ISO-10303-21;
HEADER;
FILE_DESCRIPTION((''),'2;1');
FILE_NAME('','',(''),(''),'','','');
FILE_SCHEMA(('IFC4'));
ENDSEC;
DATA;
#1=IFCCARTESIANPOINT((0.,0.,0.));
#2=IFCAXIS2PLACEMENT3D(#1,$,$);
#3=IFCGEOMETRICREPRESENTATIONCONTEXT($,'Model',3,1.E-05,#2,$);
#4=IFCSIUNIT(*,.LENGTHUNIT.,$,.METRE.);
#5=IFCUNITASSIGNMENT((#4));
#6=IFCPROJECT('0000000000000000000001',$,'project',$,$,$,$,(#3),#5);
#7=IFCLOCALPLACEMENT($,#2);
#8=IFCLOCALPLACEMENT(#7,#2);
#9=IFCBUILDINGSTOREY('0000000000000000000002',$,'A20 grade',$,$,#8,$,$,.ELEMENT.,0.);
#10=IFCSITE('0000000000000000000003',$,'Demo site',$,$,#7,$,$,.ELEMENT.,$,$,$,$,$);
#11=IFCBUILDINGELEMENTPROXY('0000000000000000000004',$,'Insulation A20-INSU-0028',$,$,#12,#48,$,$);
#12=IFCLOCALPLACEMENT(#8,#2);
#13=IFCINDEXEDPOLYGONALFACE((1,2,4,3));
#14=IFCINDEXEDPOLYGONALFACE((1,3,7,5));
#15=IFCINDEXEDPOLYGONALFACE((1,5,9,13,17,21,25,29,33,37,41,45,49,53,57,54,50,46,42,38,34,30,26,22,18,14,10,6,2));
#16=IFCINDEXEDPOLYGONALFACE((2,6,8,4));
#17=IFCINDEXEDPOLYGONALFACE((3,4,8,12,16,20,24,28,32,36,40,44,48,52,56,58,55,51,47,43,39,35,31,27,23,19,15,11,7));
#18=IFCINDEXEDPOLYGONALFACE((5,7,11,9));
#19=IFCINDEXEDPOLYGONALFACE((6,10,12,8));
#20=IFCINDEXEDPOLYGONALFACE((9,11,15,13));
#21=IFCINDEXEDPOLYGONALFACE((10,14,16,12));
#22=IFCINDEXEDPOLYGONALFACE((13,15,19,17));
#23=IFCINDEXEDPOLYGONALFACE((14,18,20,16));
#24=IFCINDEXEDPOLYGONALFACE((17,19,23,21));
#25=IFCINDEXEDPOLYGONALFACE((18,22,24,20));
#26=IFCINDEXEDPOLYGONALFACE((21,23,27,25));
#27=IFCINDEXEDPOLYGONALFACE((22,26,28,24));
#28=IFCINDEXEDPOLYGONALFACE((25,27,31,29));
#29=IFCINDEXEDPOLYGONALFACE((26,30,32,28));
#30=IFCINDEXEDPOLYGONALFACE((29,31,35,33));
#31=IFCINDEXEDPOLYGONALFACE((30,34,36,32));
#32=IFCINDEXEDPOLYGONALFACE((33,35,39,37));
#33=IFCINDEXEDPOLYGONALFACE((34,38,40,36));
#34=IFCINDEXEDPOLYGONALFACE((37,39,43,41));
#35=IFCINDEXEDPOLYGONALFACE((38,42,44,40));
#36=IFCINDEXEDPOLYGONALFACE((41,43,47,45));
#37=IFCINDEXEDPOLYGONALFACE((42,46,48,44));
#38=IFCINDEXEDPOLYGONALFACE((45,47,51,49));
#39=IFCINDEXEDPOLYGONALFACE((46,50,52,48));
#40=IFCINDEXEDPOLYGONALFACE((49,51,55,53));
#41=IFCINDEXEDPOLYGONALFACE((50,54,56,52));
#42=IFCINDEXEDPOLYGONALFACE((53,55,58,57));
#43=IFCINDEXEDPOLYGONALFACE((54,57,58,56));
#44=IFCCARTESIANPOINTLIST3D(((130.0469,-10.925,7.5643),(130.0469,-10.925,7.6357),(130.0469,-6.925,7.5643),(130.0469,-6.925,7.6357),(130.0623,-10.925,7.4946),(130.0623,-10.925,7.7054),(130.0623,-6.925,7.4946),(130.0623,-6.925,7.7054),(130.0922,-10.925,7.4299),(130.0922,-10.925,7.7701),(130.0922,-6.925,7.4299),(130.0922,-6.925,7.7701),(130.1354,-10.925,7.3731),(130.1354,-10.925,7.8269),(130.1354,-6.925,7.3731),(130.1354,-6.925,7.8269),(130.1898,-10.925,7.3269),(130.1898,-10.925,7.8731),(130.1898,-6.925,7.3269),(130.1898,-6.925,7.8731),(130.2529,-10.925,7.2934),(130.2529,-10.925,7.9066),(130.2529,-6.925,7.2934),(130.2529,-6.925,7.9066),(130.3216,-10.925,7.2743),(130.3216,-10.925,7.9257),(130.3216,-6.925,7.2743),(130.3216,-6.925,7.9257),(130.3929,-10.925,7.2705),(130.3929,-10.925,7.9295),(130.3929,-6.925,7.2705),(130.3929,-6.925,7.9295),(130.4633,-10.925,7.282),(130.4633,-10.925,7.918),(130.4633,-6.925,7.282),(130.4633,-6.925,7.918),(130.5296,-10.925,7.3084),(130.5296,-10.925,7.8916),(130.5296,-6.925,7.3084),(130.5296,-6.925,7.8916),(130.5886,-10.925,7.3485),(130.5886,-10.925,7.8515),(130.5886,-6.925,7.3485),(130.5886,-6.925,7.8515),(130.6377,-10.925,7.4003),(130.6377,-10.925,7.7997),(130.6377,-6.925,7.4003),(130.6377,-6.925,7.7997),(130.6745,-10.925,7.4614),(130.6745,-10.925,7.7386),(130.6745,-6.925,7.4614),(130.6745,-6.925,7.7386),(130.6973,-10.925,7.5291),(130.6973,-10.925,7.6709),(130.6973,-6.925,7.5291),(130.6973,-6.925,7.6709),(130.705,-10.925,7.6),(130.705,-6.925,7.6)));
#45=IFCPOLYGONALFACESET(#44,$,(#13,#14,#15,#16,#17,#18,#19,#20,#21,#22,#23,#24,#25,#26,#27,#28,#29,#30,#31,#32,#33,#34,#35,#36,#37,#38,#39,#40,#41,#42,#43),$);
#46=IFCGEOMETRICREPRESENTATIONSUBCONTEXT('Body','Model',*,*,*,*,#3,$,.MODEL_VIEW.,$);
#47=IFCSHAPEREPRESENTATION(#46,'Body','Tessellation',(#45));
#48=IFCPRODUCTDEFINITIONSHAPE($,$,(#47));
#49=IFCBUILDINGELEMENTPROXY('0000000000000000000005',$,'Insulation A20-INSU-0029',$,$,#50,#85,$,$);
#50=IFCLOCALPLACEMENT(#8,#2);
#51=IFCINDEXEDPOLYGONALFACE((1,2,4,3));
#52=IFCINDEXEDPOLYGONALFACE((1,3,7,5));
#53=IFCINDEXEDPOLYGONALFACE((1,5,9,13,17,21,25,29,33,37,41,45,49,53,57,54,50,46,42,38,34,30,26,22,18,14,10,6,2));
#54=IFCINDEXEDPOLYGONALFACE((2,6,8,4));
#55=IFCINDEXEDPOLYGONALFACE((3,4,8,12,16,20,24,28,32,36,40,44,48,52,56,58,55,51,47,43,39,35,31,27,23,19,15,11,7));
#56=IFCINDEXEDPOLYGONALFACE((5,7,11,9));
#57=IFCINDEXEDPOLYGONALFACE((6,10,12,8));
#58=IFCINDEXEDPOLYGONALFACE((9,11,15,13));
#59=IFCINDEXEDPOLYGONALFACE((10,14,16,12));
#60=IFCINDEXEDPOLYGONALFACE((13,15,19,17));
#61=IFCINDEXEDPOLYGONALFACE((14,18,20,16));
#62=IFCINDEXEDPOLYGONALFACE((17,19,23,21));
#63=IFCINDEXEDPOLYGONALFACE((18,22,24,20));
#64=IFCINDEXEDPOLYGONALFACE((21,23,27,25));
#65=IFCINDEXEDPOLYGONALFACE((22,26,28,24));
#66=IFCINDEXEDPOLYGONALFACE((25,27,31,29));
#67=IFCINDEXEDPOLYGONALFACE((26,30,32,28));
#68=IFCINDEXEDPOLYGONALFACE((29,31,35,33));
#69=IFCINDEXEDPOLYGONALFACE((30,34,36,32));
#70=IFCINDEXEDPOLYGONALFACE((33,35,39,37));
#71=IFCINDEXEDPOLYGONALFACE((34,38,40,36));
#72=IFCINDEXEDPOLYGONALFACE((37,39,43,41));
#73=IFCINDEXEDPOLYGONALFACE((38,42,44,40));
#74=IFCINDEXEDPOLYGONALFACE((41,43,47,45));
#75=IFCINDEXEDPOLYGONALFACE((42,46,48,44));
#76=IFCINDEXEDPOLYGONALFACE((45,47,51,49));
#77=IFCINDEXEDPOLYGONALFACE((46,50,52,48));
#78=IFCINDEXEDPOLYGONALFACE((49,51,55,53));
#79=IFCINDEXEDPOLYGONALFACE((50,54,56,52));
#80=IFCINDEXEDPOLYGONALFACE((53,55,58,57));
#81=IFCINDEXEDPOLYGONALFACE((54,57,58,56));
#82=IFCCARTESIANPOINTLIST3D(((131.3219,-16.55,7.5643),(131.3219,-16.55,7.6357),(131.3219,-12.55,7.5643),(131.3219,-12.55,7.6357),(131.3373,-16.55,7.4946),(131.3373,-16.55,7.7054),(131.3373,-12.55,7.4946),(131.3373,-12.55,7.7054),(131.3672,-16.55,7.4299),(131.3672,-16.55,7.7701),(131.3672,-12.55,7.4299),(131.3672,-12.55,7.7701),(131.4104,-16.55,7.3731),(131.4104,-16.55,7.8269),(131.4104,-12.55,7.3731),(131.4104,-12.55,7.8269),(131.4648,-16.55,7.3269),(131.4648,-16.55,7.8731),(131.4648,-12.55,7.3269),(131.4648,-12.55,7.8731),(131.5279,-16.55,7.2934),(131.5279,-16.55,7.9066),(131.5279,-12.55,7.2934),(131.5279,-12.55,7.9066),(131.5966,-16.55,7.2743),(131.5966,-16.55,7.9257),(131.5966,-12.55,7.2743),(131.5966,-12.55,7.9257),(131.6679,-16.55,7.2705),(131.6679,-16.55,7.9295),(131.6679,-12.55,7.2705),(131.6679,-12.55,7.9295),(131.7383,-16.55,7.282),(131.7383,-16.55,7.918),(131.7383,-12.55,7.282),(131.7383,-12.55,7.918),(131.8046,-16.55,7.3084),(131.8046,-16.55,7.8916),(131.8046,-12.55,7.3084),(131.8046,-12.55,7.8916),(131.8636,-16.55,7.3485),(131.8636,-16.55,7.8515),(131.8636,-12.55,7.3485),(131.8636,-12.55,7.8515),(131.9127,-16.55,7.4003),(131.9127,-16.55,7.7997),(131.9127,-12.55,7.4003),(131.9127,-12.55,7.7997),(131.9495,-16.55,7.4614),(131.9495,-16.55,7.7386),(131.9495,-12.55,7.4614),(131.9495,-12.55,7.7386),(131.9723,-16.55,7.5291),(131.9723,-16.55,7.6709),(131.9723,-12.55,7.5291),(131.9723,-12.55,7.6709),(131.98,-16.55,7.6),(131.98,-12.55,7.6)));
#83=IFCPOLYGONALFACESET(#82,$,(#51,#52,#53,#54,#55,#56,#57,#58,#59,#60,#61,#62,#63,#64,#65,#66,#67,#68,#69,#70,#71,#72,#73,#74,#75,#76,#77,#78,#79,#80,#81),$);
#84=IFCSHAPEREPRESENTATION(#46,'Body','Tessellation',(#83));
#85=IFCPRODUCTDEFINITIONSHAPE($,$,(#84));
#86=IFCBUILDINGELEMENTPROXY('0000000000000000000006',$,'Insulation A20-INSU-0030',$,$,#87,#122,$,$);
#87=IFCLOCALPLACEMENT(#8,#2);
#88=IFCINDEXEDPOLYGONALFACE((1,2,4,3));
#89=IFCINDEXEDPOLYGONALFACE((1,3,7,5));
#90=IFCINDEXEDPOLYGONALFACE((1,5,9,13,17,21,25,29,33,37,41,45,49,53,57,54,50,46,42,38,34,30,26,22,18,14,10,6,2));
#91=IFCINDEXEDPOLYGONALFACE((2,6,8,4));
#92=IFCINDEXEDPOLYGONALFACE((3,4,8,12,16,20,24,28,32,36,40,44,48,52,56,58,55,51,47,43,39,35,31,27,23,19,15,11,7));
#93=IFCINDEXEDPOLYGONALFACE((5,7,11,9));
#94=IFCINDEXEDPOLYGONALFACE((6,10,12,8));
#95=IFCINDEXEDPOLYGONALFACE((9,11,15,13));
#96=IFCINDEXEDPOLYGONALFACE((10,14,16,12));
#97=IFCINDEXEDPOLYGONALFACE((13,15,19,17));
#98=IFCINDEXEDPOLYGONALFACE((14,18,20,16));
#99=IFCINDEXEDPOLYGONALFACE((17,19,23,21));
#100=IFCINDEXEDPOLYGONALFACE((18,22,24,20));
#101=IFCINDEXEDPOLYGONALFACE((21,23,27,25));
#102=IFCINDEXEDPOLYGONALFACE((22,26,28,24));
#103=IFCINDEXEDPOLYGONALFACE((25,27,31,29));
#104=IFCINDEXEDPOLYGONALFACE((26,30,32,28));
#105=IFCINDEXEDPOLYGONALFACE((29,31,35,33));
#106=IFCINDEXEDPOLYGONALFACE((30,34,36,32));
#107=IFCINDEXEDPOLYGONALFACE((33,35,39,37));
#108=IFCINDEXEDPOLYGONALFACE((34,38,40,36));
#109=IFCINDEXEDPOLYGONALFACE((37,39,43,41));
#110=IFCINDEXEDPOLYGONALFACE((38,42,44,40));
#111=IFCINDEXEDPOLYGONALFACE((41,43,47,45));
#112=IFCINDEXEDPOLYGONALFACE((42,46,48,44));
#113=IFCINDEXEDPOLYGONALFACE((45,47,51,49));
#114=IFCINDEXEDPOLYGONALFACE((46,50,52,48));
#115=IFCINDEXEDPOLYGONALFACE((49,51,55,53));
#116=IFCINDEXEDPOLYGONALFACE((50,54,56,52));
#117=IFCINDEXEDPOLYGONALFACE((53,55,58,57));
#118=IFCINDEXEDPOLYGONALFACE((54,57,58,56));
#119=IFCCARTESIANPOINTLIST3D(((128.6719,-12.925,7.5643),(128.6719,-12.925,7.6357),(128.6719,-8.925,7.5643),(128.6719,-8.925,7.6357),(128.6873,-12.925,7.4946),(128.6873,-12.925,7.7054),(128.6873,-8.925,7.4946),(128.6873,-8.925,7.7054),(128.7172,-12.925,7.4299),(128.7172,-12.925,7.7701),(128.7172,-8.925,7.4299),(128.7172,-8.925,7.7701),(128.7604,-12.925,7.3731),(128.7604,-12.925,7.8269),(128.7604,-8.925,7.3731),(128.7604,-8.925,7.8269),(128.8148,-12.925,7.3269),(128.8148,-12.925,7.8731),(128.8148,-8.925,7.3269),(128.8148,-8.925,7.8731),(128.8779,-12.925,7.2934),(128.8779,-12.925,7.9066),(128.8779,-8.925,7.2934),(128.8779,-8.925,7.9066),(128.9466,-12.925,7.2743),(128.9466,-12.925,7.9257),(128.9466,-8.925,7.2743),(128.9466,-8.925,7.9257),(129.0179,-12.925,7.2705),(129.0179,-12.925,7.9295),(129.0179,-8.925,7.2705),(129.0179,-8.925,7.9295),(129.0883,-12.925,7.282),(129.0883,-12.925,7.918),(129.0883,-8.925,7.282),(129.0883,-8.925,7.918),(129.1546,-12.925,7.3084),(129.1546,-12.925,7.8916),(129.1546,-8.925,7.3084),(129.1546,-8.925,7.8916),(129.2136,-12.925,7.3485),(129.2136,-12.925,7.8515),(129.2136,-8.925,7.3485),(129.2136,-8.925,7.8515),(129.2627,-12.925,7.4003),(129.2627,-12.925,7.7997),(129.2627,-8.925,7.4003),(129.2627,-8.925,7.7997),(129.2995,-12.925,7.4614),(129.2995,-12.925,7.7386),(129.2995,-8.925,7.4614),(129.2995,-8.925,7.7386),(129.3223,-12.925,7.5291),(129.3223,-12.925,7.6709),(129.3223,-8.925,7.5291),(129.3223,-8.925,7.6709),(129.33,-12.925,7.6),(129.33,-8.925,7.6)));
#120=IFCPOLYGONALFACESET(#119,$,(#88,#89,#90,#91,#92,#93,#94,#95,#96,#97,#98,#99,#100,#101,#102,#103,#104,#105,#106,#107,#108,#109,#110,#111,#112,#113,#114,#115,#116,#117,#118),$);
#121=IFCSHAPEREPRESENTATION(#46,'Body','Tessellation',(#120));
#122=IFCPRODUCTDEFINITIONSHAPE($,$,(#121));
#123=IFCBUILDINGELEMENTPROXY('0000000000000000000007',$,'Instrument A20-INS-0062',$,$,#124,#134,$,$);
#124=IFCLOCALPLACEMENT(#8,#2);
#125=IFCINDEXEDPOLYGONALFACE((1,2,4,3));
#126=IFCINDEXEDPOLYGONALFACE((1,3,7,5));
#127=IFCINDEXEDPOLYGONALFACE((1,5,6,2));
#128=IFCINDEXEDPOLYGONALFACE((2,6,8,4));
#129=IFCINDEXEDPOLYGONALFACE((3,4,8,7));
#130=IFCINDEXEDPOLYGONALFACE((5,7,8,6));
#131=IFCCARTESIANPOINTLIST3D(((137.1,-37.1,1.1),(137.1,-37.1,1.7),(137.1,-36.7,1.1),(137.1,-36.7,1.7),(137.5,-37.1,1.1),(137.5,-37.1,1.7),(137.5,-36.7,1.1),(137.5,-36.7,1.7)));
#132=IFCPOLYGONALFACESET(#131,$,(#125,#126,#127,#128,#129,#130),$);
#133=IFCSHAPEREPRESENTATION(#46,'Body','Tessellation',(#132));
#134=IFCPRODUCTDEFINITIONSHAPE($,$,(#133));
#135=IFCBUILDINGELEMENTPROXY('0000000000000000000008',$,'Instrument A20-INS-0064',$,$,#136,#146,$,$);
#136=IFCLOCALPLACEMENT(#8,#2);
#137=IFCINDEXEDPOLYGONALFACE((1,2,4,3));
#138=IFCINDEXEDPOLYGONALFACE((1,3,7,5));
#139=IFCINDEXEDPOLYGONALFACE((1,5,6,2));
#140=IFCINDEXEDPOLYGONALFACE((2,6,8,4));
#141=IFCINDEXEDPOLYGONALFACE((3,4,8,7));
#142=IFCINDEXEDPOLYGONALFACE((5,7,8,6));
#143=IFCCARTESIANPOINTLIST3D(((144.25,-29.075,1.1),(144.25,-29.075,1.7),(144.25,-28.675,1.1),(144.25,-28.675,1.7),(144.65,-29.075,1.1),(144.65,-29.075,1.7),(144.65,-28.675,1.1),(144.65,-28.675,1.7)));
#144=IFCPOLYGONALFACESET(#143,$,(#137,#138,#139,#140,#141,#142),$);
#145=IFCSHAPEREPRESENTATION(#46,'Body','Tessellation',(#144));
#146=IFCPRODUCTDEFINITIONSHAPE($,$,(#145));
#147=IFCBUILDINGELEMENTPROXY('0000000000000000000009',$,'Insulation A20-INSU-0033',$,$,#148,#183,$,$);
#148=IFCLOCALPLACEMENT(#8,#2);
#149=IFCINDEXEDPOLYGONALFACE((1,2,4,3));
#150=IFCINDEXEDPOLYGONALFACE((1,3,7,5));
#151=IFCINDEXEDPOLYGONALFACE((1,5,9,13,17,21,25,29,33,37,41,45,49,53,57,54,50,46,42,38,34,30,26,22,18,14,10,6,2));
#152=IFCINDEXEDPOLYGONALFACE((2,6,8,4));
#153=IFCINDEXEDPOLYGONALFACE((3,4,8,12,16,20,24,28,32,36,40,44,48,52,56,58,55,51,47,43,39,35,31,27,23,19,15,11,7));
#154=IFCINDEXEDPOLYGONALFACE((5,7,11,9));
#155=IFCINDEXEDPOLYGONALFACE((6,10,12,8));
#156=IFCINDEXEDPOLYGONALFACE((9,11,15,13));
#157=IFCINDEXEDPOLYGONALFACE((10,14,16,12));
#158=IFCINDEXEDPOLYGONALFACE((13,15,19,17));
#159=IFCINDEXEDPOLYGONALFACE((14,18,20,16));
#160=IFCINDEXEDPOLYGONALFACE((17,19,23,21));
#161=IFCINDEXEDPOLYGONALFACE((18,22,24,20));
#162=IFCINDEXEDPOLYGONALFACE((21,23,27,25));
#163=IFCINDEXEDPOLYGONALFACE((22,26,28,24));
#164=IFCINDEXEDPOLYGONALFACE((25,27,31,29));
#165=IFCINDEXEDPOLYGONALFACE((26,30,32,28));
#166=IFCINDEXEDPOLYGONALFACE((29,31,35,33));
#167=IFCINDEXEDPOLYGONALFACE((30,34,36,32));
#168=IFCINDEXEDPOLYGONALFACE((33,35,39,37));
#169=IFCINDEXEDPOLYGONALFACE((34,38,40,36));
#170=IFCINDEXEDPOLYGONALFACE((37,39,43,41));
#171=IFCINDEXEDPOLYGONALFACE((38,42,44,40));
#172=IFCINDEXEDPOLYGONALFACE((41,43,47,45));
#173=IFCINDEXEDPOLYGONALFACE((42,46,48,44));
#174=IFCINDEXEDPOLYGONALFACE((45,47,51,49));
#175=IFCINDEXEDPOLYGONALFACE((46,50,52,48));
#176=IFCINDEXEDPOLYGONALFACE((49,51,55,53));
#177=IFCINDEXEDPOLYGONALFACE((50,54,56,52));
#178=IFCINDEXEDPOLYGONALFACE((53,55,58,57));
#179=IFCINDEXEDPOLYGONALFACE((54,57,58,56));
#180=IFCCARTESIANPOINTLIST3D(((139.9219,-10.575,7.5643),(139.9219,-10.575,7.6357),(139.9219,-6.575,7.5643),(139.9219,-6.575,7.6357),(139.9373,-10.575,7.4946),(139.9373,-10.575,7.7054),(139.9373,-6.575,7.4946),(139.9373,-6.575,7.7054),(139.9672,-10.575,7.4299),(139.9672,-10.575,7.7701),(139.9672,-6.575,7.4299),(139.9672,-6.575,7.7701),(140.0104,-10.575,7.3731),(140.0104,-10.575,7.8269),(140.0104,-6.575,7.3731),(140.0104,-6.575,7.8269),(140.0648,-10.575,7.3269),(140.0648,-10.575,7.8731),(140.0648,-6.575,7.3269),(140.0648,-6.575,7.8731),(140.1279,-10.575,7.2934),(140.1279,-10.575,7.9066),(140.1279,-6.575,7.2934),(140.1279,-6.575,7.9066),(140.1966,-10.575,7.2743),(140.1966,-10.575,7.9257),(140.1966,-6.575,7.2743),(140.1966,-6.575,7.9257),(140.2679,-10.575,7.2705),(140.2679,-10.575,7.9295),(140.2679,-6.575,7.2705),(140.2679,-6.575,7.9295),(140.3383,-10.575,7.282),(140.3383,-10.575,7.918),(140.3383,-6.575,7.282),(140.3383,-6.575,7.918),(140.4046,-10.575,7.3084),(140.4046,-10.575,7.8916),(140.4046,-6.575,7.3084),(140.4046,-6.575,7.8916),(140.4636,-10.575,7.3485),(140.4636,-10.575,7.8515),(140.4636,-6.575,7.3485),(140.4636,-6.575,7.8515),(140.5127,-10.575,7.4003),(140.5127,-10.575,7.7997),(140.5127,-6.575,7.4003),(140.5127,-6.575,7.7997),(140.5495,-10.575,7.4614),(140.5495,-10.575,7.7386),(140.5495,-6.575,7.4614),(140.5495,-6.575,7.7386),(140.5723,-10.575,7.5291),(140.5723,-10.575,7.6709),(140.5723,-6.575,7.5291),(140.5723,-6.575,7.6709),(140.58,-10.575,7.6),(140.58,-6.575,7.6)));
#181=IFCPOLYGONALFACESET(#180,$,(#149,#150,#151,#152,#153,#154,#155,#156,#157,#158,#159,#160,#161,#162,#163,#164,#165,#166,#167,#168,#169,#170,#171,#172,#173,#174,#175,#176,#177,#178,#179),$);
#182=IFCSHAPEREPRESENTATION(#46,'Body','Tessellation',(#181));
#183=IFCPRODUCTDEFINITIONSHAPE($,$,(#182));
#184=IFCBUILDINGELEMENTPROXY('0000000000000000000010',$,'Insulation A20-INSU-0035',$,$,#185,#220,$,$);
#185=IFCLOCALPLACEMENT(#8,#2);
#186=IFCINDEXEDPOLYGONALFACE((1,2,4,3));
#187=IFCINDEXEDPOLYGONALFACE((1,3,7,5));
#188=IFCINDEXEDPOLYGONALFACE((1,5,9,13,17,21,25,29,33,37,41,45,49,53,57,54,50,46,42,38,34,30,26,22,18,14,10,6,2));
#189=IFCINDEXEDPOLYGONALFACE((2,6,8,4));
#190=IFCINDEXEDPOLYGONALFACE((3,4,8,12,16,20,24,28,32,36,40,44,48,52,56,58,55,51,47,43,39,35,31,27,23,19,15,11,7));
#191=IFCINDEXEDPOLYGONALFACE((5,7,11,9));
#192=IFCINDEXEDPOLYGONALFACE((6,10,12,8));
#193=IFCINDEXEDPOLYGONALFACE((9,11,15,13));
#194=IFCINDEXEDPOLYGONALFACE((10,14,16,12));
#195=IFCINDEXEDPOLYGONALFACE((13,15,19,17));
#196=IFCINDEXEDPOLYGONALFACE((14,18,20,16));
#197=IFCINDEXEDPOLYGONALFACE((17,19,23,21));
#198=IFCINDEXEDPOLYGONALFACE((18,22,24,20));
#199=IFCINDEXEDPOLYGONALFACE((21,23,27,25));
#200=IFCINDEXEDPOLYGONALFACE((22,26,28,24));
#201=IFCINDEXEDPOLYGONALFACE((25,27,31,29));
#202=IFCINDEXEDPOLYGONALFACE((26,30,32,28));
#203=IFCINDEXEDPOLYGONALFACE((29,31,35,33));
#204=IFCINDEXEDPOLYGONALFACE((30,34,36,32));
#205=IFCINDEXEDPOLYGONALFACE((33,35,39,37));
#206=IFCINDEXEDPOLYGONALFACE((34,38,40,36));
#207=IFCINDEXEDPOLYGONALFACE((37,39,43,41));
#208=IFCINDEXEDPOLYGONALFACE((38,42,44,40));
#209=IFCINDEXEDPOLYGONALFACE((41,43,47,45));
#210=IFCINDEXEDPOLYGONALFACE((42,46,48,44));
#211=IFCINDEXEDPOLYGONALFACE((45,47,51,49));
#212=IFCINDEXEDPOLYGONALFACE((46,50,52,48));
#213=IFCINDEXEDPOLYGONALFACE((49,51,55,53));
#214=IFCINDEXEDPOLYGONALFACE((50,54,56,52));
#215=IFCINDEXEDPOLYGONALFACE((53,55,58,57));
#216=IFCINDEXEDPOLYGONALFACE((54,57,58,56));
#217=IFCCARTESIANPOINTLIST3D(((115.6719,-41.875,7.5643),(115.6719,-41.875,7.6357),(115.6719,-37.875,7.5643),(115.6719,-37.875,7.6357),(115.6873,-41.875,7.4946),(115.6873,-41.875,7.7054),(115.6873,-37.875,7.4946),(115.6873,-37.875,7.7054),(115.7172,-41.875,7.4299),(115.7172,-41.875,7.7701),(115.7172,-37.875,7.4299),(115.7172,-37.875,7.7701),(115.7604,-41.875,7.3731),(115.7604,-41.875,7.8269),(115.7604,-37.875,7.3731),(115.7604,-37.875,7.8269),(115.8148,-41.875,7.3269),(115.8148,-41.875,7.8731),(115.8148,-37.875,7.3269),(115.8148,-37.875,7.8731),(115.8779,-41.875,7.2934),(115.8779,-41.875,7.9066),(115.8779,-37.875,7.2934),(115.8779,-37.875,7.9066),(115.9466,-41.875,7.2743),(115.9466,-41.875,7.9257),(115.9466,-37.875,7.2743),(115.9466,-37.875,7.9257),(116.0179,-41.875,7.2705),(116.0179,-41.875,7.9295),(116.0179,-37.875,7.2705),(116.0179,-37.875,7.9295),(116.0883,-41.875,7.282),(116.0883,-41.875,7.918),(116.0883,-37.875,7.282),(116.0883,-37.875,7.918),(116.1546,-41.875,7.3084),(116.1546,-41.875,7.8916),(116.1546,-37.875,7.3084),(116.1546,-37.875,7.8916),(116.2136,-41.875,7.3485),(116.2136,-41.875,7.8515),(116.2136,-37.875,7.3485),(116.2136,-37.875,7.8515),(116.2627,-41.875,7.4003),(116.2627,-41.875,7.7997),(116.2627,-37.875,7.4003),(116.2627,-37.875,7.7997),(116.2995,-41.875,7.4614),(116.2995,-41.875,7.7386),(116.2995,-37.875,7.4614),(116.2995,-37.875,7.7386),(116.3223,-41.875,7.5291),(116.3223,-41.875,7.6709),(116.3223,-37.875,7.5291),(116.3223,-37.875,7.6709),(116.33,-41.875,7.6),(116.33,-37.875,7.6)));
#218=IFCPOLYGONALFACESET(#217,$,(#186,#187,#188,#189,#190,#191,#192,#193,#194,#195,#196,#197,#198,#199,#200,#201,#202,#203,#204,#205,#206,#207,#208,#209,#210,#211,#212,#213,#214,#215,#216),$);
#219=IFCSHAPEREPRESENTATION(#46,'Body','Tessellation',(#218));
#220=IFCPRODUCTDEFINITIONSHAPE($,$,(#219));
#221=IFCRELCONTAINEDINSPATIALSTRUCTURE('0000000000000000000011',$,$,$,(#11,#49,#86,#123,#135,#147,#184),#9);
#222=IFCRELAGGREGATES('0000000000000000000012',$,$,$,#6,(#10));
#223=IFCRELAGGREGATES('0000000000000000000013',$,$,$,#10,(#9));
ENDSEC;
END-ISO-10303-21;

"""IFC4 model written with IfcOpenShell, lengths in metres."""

from ifc_helpers import new_model, si_unit, frame, origin, place, context, subcontext, project, spatial, rectangle, circle, extrude, element, save


model = new_model("IFC4")

# Units and contexts
model_context = context("Model", 3, precision=1e-05, world=origin())
body_context = subcontext(model_context, "Body", "Model", "MODEL_VIEW")
ifc_project = project(units=[si_unit("LENGTHUNIT", "METRE")], contexts=[model_context])

# Site, storey
site_placement = place(None, origin())
site = spatial("IfcSite", under=ifc_project, at=site_placement, Name="Demo site", CompositionType="ELEMENT")
storey_placement = place(site_placement, origin())
storey = spatial("IfcBuildingStorey", under=site, at=storey_placement, Name="A20 grade", CompositionType="ELEMENT", Elevation=0.0)

# Building element proxies
for number, where, name in (
    (1, (130.375, -10.925, 7.6), "Insulation A20-INSU-0028"),
    (2, (131.65, -16.55, 7.6), "Insulation A20-INSU-0029"),
    (3, (129.0, -12.925, 7.6), "Insulation A20-INSU-0030"),
):
    element("IfcBuildingElementProxy", number, at=place(storey_placement, frame(where)), inside=storey, Name=name, context=body_context, shape_type="SweptSolid", body=[
        extrude(circle(Radius=0.33), frame((0.0, 0.0, 0.0), z_axis=(0.0, 1.0, 0.0), x_axis=(1.0, 0.0, 0.0)), (0.0, 0.0, 1.0), 4.0),
    ])
for number, where, name in (
    (4, (137.3, -36.9, 1.1), "Instrument A20-INS-0062"),
    (5, (144.45, -28.875, 1.1), "Instrument A20-INS-0064"),
):
    element("IfcBuildingElementProxy", number, at=place(storey_placement, frame(where)), inside=storey, Name=name, context=body_context, shape_type="SweptSolid", body=[
        extrude(rectangle(XDim=0.4, YDim=0.4), origin(), (0.0, 0.0, 1.0), 0.6),
    ])
for number, where, name in (
    (6, (140.25, -10.575, 7.6), "Insulation A20-INSU-0033"),
    (7, (116.0, -41.875, 7.6), "Insulation A20-INSU-0035"),
):
    element("IfcBuildingElementProxy", number, at=place(storey_placement, frame(where)), inside=storey, Name=name, context=body_context, shape_type="SweptSolid", body=[
        extrude(circle(Radius=0.33), frame((0.0, 0.0, 0.0), z_axis=(0.0, 1.0, 0.0), x_axis=(1.0, 0.0, 0.0)), (0.0, 0.0, 1.0), 4.0),
    ])

save(model, "model.ifc")
